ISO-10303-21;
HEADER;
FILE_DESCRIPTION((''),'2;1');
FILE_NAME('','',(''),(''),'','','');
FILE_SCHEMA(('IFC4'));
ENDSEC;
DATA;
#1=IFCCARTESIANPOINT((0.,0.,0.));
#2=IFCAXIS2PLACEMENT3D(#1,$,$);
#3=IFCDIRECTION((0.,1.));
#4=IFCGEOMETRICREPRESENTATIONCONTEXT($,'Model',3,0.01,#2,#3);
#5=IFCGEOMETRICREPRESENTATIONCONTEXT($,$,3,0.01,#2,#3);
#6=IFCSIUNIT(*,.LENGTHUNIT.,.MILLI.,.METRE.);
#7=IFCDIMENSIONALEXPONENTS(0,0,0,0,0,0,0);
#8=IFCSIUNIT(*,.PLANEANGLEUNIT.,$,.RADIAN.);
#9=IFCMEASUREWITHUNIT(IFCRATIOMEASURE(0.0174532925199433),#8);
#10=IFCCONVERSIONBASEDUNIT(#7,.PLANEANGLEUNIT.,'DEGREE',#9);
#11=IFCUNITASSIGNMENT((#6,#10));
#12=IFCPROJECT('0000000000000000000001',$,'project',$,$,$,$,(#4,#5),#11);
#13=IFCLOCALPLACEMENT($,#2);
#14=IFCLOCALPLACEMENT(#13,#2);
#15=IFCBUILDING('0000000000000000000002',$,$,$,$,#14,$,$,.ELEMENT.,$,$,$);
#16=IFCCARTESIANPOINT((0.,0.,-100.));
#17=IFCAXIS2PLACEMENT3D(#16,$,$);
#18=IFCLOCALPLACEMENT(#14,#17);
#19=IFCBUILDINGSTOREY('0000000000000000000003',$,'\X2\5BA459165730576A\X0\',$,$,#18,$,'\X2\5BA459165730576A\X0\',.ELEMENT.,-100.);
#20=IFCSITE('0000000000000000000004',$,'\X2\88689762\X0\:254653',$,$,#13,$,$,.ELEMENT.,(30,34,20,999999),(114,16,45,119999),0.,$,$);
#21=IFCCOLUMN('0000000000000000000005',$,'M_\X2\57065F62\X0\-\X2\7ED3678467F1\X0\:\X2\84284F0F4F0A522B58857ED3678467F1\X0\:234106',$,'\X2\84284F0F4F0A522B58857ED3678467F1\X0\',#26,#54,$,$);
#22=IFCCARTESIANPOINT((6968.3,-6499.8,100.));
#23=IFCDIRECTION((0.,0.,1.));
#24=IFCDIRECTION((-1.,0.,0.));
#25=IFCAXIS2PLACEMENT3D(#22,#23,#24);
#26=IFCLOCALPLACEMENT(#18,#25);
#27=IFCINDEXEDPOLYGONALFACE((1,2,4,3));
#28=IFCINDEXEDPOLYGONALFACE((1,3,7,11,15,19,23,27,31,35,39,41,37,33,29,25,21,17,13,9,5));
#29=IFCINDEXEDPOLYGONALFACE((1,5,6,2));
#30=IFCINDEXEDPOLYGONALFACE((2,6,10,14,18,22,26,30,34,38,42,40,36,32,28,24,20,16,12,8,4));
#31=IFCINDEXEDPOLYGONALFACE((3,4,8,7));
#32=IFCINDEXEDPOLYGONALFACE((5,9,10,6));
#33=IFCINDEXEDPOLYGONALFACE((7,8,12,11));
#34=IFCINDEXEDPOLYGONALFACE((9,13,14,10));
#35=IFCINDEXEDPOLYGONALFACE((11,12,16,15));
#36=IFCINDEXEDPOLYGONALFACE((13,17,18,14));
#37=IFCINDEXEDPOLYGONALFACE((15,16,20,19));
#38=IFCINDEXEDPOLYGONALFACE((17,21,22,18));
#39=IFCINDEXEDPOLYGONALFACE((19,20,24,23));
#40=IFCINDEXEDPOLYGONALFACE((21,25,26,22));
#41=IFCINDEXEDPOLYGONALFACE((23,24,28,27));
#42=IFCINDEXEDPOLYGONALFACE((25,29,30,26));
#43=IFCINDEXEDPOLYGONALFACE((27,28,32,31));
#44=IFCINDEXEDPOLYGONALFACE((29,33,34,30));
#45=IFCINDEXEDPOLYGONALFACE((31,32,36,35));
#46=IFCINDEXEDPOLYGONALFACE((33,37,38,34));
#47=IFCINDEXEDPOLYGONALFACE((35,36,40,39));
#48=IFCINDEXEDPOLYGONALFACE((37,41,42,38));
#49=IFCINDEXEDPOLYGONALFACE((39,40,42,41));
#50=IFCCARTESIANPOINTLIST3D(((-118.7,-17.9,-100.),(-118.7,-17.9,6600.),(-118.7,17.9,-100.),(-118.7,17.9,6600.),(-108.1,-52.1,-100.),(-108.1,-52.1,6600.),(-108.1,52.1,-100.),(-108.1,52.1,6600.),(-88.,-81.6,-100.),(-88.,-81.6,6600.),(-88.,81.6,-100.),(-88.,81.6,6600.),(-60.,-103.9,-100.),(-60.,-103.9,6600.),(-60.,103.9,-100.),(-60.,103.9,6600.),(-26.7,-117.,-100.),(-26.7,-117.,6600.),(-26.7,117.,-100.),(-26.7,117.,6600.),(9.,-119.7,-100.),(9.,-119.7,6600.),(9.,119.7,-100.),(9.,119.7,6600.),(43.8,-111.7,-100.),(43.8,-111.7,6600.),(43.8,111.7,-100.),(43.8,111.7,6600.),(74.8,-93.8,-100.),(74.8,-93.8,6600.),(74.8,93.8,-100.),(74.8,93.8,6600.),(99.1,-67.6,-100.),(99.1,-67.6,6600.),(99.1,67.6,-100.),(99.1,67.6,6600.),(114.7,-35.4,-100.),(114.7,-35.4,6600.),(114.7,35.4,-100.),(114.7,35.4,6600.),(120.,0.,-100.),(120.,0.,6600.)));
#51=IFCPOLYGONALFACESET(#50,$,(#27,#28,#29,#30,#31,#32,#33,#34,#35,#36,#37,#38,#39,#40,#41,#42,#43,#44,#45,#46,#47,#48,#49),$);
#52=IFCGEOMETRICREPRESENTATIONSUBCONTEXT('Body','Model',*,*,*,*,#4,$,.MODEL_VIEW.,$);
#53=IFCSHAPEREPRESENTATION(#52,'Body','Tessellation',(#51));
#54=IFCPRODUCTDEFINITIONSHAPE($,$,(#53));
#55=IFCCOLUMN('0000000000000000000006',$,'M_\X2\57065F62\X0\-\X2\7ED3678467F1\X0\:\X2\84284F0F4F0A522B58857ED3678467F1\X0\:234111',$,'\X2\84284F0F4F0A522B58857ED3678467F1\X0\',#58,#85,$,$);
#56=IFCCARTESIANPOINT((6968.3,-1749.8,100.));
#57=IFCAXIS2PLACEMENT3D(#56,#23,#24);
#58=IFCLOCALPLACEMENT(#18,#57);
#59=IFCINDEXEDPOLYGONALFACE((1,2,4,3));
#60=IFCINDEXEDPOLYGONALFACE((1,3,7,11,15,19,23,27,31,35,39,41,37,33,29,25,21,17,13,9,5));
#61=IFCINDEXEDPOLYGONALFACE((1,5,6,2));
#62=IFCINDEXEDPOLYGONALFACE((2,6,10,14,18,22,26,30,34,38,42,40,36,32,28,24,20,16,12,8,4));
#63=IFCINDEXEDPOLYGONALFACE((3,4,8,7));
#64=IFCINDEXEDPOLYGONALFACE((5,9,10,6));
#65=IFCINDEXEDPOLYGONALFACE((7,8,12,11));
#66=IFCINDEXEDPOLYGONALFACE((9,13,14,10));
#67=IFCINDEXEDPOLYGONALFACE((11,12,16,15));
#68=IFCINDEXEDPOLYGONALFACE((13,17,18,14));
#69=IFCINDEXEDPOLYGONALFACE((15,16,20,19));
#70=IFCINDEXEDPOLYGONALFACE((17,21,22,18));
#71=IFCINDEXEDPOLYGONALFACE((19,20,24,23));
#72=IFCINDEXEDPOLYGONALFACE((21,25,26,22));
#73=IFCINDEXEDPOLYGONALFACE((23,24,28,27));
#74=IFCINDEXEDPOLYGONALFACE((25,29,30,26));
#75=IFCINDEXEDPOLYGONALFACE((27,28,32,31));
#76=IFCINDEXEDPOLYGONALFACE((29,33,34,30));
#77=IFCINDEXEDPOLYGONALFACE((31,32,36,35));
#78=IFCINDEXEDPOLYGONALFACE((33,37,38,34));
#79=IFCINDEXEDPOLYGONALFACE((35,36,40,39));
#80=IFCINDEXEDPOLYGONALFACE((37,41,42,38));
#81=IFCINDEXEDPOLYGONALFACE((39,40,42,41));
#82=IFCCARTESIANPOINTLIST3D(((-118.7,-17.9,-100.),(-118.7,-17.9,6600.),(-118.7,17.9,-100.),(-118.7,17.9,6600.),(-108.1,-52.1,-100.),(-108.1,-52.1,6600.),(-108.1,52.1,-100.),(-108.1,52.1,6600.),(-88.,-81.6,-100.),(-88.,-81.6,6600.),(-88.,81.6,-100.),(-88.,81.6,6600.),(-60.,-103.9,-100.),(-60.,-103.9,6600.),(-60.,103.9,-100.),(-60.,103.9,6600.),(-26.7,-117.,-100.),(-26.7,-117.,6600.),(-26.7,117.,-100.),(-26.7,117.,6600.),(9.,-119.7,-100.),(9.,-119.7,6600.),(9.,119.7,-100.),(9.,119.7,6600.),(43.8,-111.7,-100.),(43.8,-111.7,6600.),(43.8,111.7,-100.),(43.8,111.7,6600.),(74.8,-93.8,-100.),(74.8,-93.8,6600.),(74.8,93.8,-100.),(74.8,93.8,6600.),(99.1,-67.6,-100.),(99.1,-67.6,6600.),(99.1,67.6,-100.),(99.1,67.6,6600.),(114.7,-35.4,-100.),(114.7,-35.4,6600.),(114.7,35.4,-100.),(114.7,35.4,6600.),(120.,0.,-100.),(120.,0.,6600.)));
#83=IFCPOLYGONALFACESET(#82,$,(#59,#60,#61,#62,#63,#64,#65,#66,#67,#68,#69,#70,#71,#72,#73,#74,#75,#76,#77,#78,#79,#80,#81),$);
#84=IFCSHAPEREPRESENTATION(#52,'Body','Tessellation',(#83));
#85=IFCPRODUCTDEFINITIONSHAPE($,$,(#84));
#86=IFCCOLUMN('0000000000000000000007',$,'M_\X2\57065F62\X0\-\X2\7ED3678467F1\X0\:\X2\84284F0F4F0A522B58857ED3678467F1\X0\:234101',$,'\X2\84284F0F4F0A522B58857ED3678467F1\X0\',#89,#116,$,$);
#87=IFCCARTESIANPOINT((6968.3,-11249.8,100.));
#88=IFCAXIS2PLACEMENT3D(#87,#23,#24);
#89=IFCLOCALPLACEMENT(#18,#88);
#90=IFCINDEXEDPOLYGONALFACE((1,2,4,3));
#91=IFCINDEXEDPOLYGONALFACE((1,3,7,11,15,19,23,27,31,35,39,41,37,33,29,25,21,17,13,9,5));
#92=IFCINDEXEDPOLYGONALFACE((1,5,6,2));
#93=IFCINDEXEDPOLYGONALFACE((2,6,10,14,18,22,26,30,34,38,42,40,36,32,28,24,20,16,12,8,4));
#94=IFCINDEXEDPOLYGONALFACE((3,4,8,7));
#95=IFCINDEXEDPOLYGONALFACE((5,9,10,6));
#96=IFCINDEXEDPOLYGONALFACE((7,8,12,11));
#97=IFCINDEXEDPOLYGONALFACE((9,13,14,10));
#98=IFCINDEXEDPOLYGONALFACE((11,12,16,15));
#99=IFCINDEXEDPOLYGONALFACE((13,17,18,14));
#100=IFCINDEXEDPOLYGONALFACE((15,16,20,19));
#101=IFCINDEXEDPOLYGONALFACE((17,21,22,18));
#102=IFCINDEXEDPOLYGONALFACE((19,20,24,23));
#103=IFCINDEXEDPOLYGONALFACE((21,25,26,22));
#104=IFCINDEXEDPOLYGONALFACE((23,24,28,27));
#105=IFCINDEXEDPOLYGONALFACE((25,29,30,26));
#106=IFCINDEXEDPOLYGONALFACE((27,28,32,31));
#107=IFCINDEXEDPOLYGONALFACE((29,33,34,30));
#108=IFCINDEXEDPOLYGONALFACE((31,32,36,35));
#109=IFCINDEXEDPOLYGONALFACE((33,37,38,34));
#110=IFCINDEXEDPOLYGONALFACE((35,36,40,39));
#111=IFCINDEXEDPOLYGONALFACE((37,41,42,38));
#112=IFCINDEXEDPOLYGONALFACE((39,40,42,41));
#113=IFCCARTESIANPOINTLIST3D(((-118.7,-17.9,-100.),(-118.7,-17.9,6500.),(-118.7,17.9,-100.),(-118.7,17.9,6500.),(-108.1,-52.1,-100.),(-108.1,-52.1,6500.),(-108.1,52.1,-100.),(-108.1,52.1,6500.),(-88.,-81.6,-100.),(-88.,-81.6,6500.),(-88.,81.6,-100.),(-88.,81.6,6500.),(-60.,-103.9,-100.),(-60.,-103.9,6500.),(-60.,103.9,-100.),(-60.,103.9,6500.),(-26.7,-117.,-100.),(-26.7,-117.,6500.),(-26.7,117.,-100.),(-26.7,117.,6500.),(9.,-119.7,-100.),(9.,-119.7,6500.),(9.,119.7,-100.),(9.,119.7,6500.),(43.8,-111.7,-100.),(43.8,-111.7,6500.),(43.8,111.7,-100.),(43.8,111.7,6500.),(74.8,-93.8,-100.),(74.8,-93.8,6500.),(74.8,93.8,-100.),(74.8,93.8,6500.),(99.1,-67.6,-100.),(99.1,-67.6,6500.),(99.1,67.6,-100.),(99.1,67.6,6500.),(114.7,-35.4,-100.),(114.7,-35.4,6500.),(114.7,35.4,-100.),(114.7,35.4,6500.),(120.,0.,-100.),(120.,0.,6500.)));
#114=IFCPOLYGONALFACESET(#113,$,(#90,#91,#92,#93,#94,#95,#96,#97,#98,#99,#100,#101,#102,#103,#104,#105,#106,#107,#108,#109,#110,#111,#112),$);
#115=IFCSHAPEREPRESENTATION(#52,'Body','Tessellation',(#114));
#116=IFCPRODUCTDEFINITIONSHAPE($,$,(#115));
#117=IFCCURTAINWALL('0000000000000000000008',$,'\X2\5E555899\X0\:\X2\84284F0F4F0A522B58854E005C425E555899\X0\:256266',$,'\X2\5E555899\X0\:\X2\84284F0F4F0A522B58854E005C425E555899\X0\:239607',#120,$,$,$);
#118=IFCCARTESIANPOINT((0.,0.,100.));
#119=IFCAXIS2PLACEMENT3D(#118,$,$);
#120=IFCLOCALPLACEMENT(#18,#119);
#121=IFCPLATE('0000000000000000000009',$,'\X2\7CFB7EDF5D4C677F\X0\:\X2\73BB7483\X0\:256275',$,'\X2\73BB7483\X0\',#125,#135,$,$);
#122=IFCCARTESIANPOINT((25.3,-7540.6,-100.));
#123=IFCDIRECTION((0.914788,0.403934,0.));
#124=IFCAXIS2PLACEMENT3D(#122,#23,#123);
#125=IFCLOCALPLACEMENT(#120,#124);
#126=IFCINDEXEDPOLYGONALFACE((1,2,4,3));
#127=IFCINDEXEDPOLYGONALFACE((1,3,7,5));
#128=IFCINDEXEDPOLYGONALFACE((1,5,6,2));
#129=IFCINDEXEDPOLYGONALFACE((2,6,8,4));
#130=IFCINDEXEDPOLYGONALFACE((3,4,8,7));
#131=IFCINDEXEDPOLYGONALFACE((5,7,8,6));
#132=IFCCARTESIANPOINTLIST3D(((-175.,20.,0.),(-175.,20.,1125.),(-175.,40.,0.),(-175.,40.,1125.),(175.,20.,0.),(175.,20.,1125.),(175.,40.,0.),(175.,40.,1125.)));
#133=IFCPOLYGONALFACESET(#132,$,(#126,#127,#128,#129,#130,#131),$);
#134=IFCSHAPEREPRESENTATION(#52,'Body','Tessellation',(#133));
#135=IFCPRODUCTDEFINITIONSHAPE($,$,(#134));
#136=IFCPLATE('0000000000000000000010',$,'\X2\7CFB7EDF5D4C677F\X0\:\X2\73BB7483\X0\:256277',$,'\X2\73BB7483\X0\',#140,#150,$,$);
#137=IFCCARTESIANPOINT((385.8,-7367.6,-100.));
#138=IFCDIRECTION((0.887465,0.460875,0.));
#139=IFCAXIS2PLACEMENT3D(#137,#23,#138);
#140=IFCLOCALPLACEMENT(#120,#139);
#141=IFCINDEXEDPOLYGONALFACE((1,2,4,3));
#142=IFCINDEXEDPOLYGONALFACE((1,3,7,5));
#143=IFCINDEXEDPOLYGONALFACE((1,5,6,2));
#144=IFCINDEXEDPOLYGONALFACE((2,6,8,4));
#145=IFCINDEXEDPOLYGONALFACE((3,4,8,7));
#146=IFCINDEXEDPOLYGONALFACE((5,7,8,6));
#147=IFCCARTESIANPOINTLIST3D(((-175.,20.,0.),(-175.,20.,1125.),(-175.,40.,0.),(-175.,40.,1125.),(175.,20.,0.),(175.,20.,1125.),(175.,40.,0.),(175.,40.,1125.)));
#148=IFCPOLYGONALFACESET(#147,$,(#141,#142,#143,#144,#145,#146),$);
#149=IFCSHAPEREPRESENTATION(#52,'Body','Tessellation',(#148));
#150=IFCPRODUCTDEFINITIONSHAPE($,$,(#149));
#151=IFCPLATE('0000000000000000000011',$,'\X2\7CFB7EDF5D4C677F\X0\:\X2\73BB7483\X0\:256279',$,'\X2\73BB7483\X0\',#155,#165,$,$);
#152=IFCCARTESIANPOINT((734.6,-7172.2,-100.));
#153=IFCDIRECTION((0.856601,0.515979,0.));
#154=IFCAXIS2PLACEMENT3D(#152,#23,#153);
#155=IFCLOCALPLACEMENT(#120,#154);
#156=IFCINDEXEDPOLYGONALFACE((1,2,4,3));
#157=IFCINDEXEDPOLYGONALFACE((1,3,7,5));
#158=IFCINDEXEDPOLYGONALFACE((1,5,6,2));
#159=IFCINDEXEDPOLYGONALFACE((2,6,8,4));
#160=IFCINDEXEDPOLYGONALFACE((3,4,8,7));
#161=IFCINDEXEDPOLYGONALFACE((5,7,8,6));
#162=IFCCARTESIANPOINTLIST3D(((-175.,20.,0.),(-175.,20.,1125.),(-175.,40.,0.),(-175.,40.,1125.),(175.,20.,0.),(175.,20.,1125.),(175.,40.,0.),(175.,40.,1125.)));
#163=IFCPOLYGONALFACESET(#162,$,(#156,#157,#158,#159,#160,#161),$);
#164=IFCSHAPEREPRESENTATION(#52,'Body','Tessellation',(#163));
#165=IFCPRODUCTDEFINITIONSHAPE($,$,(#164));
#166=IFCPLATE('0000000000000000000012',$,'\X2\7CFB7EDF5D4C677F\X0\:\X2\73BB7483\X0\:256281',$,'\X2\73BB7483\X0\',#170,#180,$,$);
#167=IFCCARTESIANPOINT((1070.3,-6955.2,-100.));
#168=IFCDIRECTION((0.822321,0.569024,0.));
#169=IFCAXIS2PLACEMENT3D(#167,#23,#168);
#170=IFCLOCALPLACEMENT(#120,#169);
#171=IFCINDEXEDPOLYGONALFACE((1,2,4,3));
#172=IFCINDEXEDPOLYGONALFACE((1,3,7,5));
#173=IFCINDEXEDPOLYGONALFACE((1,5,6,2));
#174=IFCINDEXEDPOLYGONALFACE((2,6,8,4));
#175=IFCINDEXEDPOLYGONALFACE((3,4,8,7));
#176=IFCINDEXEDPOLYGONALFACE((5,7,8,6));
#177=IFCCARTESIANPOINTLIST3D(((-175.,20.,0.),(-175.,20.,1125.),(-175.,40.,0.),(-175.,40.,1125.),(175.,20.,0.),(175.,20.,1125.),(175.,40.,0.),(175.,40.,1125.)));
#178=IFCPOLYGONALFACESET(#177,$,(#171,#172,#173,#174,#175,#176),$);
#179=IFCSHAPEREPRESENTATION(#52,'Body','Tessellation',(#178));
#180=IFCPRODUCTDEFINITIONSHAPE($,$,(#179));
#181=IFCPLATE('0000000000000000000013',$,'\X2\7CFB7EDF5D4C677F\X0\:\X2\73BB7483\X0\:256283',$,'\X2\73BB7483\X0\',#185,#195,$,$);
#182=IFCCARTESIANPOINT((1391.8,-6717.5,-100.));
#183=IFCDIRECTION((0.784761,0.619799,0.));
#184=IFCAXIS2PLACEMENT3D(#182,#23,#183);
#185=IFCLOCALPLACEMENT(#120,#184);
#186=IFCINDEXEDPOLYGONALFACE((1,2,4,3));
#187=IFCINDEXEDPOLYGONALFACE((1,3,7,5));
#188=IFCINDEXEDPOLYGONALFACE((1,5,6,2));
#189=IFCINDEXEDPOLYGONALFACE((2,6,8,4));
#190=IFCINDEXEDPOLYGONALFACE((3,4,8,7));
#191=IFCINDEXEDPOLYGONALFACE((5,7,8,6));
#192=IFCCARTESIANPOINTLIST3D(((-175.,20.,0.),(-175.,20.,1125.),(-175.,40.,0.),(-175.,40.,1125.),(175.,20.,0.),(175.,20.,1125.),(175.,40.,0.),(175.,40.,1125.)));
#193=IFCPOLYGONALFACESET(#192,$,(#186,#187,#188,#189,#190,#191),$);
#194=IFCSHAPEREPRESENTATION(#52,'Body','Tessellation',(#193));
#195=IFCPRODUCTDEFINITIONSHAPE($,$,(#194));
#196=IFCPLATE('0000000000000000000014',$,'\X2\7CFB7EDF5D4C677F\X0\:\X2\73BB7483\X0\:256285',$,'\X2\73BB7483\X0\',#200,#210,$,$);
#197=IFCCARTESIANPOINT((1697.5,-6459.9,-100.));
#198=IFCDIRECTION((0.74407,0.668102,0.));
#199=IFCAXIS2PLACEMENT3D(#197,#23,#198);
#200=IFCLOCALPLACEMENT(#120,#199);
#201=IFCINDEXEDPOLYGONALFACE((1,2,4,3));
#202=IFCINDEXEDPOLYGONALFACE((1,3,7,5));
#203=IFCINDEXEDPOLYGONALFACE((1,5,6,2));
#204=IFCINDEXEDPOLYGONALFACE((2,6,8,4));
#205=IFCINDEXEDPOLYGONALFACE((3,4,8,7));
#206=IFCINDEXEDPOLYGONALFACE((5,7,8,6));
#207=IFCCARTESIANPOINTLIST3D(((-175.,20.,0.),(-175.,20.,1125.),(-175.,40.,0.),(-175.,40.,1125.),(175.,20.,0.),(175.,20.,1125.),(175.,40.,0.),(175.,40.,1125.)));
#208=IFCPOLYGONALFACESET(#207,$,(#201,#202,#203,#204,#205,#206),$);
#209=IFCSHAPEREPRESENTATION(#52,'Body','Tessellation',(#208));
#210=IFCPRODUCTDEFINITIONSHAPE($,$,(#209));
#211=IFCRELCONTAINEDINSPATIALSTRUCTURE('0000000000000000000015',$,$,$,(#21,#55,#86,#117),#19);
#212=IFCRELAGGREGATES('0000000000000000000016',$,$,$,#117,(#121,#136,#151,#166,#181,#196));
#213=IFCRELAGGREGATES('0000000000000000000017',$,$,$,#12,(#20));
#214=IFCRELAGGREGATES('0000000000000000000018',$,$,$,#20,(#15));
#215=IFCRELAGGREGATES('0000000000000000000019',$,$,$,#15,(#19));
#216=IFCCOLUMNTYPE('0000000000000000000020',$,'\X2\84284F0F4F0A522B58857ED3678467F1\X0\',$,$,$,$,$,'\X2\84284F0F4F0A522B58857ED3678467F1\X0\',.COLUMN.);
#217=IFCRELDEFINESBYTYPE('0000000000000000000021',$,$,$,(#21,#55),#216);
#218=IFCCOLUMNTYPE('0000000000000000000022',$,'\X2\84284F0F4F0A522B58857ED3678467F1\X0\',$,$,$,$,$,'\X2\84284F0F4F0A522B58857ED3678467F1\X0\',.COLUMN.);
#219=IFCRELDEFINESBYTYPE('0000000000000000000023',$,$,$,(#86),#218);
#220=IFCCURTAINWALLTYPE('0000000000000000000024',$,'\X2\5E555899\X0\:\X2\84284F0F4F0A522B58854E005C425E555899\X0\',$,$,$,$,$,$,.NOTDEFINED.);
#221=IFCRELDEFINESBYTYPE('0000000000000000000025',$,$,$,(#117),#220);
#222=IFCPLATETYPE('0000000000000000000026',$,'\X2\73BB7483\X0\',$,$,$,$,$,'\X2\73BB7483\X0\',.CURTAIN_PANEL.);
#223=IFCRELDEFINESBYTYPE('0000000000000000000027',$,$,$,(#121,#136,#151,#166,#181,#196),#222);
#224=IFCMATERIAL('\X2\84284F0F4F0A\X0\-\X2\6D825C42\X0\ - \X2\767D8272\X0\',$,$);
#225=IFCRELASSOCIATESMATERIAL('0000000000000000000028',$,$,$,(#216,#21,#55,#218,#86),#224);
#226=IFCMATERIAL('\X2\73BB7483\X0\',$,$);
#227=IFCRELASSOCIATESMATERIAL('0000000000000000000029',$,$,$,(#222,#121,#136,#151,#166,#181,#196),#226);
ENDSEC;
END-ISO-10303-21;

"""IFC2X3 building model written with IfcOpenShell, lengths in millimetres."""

from ifc_helpers import new_model, entity, si_unit, converted_unit, direction, frame, frame_2d, origin, place, context, subcontext, project, spatial, rectangle, circle, extrude, source, transform, mapped, material, type_object, type_shapes, element, aggregate, save


model = new_model("IFC2X3")

# Units and contexts
model_context = context("Model", 3, precision=0.01, world=origin(), true_north=direction((0.0, 1.0)))
context_of_model = context(None, 3, precision=0.01, world=origin(), true_north=direction((0.0, 1.0)))
body_context = subcontext(model_context, "Body", "Model", "MODEL_VIEW")
ifc_project = project(units=[si_unit("LENGTHUNIT", "METRE", prefix="MILLI"), converted_unit("PLANEANGLEUNIT", "DEGREE", entity("IfcRatioMeasure", 0.0174532925199433), si_unit("PLANEANGLEUNIT", "RADIAN"), dimensions=[0, 0, 0, 0, 0, 0, 0])], contexts=[model_context, context_of_model])

# Site, building, storey
site_placement = place(None, origin())
site = spatial("IfcSite", under=ifc_project, at=site_placement, Name="表面:254653", CompositionType="ELEMENT", RefLatitude=(30, 34, 20, 999999), RefLongitude=(114, 16, 45, 119999), RefElevation=0.0)
building_placement = place(site_placement, origin())
building = spatial("IfcBuilding", under=site, at=building_placement, CompositionType="ELEMENT")
storey_placement = place(building_placement, frame((0.0, 0.0, -100.0)))
storey = spatial("IfcBuildingStorey", under=building, at=storey_placement, Name="室外地坪", LongName="室外地坪", CompositionType="ELEMENT", Elevation=-100.0)

# Columns
ifc_material_1 = material(Name="萨伏伊-涂层 - 白色")
column_type_1 = type_object("IfcColumnType", Name="萨伏伊别墅结构柱", ElementType="萨伏伊别墅结构柱", PredefinedType="COLUMN", material=ifc_material_1)
shared_shape_1 = source(origin(), body_context, "Body", "SweptSolid", [
    extrude(circle(Radius=120.0, at=frame_2d((0.0, 0.0), x_axis=(1.0, 0.0))), frame((0.0, 0.0, -100.0)), (0.0, 0.0, 1.0), 6700.0),
])
type_shapes(column_type_1, [shared_shape_1])
for number, where, z_axis, x_axis, name in (
    (1, (6968.3, -6499.8, 100.0), (0.0, 0.0, 1.0), (-1.0, 0.0, 0.0), "M_圆形-结构柱:萨伏伊别墅结构柱:234106"),
    (2, (6968.3, -1749.8, 100.0), (0.0, 0.0, 1.0), (-1.0, 0.0, 0.0), "M_圆形-结构柱:萨伏伊别墅结构柱:234111"),
):
    element("IfcColumn", number, at=place(storey_placement, frame(where, z_axis=z_axis, x_axis=x_axis)), inside=storey, type_object=column_type_1, material=ifc_material_1, Name=name, ObjectType="萨伏伊别墅结构柱", context=body_context, shape_type="MappedRepresentation", body=[
        mapped(shared_shape_1, transform((0.0, 0.0, 0.0), scale=1.0)),
    ])
column_type_2 = type_object("IfcColumnType", Name="萨伏伊别墅结构柱", ElementType="萨伏伊别墅结构柱", PredefinedType="COLUMN", material=ifc_material_1)
shared_shape_2 = source(origin(), body_context, "Body", "SweptSolid", [
    extrude(circle(Radius=120.0, at=frame_2d((0.0, 0.0), x_axis=(1.0, 0.0))), frame((0.0, 0.0, -100.0)), (0.0, 0.0, 1.0), 6600.0),
])
type_shapes(column_type_2, [shared_shape_2])
column_placement = place(storey_placement, frame((6968.3, -11249.8, 100.0), z_axis=(0.0, 0.0, 1.0), x_axis=(-1.0, 0.0, 0.0)))
element("IfcColumn", 3, at=column_placement, inside=storey, type_object=column_type_2, material=ifc_material_1, Name="M_圆形-结构柱:萨伏伊别墅结构柱:234101", ObjectType="萨伏伊别墅结构柱", context=body_context, shape_type="MappedRepresentation", body=[
    mapped(shared_shape_2, transform((0.0, 0.0, 0.0), scale=1.0)),
])

# Curtain wall, plates
curtain_wall_type = type_object("IfcCurtainWallType", Name="幕墙:萨伏伊别墅一层幕墙", PredefinedType="NOTDEFINED")
curtain_wall_placement = place(storey_placement, frame((0.0, 0.0, 100.0)))
curtain_wall = element("IfcCurtainWall", 4, at=curtain_wall_placement, inside=storey, type_object=curtain_wall_type, Name="幕墙:萨伏伊别墅一层幕墙:256266", ObjectType="幕墙:萨伏伊别墅一层幕墙:239607")
ifc_material_2 = material(Name="玻璃")
plate_type_1 = type_object("IfcPlateType", Name="玻璃", ElementType="玻璃", PredefinedType="CURTAIN_PANEL", material=ifc_material_2)
shared_shape_3 = source(origin(), body_context, "Body", "SweptSolid", [
    extrude(rectangle(XDim=20.0, YDim=350.0, at=frame_2d((0.0, 0.0), x_axis=(1.0, 0.0))), frame((0.0, 30.0, 0.0), z_axis=(0.0, 0.0, 1.0), x_axis=(0.0, 1.0, 0.0)), (0.0, 0.0, 1.0), 1125.0),
])
type_shapes(plate_type_1, [shared_shape_3])
plate_1_placement = place(curtain_wall_placement, frame((25.3, -7540.6, -100.0), z_axis=(0.0, 0.0, 1.0), x_axis=(0.914788, 0.403934, 0.0)))
plate_1 = element("IfcPlate", 5, at=plate_1_placement, type_object=plate_type_1, material=ifc_material_2, Name="系统嵌板:玻璃:256275", ObjectType="玻璃", context=body_context, shape_type="MappedRepresentation", body=[
    mapped(shared_shape_3, transform((0.0, 0.0, 0.0), scale=1.0)),
])
plate_2_placement = place(curtain_wall_placement, frame((385.8, -7367.6, -100.0), z_axis=(0.0, 0.0, 1.0), x_axis=(0.887465, 0.460875, 0.0)))
plate_2 = element("IfcPlate", 6, at=plate_2_placement, type_object=plate_type_1, material=ifc_material_2, Name="系统嵌板:玻璃:256277", ObjectType="玻璃", context=body_context, shape_type="MappedRepresentation", body=[
    mapped(shared_shape_3, transform((0.0, 0.0, 0.0), scale=1.0)),
])
plate_3_placement = place(curtain_wall_placement, frame((734.6, -7172.2, -100.0), z_axis=(0.0, 0.0, 1.0), x_axis=(0.856601, 0.515979, 0.0)))
plate_3 = element("IfcPlate", 7, at=plate_3_placement, type_object=plate_type_1, material=ifc_material_2, Name="系统嵌板:玻璃:256279", ObjectType="玻璃", context=body_context, shape_type="MappedRepresentation", body=[
    mapped(shared_shape_3, transform((0.0, 0.0, 0.0), scale=1.0)),
])
plate_4_placement = place(curtain_wall_placement, frame((1070.3, -6955.2, -100.0), z_axis=(0.0, 0.0, 1.0), x_axis=(0.822321, 0.569024, 0.0)))
plate_4 = element("IfcPlate", 8, at=plate_4_placement, type_object=plate_type_1, material=ifc_material_2, Name="系统嵌板:玻璃:256281", ObjectType="玻璃", context=body_context, shape_type="MappedRepresentation", body=[
    mapped(shared_shape_3, transform((0.0, 0.0, 0.0), scale=1.0)),
])
plate_5_placement = place(curtain_wall_placement, frame((1391.8, -6717.5, -100.0), z_axis=(0.0, 0.0, 1.0), x_axis=(0.784761, 0.619799, 0.0)))
plate_5 = element("IfcPlate", 9, at=plate_5_placement, type_object=plate_type_1, material=ifc_material_2, Name="系统嵌板:玻璃:256283", ObjectType="玻璃", context=body_context, shape_type="MappedRepresentation", body=[
    mapped(shared_shape_3, transform((0.0, 0.0, 0.0), scale=1.0)),
])
plate_6_placement = place(curtain_wall_placement, frame((1697.5, -6459.9, -100.0), z_axis=(0.0, 0.0, 1.0), x_axis=(0.74407, 0.668102, 0.0)))
plate_6 = element("IfcPlate", 10, at=plate_6_placement, type_object=plate_type_1, material=ifc_material_2, Name="系统嵌板:玻璃:256285", ObjectType="玻璃", context=body_context, shape_type="MappedRepresentation", body=[
    mapped(shared_shape_3, transform((0.0, 0.0, 0.0), scale=1.0)),
])
aggregate(curtain_wall, [plate_1, plate_2, plate_3, plate_4, plate_5, plate_6])

save(model, "model.ifc")
